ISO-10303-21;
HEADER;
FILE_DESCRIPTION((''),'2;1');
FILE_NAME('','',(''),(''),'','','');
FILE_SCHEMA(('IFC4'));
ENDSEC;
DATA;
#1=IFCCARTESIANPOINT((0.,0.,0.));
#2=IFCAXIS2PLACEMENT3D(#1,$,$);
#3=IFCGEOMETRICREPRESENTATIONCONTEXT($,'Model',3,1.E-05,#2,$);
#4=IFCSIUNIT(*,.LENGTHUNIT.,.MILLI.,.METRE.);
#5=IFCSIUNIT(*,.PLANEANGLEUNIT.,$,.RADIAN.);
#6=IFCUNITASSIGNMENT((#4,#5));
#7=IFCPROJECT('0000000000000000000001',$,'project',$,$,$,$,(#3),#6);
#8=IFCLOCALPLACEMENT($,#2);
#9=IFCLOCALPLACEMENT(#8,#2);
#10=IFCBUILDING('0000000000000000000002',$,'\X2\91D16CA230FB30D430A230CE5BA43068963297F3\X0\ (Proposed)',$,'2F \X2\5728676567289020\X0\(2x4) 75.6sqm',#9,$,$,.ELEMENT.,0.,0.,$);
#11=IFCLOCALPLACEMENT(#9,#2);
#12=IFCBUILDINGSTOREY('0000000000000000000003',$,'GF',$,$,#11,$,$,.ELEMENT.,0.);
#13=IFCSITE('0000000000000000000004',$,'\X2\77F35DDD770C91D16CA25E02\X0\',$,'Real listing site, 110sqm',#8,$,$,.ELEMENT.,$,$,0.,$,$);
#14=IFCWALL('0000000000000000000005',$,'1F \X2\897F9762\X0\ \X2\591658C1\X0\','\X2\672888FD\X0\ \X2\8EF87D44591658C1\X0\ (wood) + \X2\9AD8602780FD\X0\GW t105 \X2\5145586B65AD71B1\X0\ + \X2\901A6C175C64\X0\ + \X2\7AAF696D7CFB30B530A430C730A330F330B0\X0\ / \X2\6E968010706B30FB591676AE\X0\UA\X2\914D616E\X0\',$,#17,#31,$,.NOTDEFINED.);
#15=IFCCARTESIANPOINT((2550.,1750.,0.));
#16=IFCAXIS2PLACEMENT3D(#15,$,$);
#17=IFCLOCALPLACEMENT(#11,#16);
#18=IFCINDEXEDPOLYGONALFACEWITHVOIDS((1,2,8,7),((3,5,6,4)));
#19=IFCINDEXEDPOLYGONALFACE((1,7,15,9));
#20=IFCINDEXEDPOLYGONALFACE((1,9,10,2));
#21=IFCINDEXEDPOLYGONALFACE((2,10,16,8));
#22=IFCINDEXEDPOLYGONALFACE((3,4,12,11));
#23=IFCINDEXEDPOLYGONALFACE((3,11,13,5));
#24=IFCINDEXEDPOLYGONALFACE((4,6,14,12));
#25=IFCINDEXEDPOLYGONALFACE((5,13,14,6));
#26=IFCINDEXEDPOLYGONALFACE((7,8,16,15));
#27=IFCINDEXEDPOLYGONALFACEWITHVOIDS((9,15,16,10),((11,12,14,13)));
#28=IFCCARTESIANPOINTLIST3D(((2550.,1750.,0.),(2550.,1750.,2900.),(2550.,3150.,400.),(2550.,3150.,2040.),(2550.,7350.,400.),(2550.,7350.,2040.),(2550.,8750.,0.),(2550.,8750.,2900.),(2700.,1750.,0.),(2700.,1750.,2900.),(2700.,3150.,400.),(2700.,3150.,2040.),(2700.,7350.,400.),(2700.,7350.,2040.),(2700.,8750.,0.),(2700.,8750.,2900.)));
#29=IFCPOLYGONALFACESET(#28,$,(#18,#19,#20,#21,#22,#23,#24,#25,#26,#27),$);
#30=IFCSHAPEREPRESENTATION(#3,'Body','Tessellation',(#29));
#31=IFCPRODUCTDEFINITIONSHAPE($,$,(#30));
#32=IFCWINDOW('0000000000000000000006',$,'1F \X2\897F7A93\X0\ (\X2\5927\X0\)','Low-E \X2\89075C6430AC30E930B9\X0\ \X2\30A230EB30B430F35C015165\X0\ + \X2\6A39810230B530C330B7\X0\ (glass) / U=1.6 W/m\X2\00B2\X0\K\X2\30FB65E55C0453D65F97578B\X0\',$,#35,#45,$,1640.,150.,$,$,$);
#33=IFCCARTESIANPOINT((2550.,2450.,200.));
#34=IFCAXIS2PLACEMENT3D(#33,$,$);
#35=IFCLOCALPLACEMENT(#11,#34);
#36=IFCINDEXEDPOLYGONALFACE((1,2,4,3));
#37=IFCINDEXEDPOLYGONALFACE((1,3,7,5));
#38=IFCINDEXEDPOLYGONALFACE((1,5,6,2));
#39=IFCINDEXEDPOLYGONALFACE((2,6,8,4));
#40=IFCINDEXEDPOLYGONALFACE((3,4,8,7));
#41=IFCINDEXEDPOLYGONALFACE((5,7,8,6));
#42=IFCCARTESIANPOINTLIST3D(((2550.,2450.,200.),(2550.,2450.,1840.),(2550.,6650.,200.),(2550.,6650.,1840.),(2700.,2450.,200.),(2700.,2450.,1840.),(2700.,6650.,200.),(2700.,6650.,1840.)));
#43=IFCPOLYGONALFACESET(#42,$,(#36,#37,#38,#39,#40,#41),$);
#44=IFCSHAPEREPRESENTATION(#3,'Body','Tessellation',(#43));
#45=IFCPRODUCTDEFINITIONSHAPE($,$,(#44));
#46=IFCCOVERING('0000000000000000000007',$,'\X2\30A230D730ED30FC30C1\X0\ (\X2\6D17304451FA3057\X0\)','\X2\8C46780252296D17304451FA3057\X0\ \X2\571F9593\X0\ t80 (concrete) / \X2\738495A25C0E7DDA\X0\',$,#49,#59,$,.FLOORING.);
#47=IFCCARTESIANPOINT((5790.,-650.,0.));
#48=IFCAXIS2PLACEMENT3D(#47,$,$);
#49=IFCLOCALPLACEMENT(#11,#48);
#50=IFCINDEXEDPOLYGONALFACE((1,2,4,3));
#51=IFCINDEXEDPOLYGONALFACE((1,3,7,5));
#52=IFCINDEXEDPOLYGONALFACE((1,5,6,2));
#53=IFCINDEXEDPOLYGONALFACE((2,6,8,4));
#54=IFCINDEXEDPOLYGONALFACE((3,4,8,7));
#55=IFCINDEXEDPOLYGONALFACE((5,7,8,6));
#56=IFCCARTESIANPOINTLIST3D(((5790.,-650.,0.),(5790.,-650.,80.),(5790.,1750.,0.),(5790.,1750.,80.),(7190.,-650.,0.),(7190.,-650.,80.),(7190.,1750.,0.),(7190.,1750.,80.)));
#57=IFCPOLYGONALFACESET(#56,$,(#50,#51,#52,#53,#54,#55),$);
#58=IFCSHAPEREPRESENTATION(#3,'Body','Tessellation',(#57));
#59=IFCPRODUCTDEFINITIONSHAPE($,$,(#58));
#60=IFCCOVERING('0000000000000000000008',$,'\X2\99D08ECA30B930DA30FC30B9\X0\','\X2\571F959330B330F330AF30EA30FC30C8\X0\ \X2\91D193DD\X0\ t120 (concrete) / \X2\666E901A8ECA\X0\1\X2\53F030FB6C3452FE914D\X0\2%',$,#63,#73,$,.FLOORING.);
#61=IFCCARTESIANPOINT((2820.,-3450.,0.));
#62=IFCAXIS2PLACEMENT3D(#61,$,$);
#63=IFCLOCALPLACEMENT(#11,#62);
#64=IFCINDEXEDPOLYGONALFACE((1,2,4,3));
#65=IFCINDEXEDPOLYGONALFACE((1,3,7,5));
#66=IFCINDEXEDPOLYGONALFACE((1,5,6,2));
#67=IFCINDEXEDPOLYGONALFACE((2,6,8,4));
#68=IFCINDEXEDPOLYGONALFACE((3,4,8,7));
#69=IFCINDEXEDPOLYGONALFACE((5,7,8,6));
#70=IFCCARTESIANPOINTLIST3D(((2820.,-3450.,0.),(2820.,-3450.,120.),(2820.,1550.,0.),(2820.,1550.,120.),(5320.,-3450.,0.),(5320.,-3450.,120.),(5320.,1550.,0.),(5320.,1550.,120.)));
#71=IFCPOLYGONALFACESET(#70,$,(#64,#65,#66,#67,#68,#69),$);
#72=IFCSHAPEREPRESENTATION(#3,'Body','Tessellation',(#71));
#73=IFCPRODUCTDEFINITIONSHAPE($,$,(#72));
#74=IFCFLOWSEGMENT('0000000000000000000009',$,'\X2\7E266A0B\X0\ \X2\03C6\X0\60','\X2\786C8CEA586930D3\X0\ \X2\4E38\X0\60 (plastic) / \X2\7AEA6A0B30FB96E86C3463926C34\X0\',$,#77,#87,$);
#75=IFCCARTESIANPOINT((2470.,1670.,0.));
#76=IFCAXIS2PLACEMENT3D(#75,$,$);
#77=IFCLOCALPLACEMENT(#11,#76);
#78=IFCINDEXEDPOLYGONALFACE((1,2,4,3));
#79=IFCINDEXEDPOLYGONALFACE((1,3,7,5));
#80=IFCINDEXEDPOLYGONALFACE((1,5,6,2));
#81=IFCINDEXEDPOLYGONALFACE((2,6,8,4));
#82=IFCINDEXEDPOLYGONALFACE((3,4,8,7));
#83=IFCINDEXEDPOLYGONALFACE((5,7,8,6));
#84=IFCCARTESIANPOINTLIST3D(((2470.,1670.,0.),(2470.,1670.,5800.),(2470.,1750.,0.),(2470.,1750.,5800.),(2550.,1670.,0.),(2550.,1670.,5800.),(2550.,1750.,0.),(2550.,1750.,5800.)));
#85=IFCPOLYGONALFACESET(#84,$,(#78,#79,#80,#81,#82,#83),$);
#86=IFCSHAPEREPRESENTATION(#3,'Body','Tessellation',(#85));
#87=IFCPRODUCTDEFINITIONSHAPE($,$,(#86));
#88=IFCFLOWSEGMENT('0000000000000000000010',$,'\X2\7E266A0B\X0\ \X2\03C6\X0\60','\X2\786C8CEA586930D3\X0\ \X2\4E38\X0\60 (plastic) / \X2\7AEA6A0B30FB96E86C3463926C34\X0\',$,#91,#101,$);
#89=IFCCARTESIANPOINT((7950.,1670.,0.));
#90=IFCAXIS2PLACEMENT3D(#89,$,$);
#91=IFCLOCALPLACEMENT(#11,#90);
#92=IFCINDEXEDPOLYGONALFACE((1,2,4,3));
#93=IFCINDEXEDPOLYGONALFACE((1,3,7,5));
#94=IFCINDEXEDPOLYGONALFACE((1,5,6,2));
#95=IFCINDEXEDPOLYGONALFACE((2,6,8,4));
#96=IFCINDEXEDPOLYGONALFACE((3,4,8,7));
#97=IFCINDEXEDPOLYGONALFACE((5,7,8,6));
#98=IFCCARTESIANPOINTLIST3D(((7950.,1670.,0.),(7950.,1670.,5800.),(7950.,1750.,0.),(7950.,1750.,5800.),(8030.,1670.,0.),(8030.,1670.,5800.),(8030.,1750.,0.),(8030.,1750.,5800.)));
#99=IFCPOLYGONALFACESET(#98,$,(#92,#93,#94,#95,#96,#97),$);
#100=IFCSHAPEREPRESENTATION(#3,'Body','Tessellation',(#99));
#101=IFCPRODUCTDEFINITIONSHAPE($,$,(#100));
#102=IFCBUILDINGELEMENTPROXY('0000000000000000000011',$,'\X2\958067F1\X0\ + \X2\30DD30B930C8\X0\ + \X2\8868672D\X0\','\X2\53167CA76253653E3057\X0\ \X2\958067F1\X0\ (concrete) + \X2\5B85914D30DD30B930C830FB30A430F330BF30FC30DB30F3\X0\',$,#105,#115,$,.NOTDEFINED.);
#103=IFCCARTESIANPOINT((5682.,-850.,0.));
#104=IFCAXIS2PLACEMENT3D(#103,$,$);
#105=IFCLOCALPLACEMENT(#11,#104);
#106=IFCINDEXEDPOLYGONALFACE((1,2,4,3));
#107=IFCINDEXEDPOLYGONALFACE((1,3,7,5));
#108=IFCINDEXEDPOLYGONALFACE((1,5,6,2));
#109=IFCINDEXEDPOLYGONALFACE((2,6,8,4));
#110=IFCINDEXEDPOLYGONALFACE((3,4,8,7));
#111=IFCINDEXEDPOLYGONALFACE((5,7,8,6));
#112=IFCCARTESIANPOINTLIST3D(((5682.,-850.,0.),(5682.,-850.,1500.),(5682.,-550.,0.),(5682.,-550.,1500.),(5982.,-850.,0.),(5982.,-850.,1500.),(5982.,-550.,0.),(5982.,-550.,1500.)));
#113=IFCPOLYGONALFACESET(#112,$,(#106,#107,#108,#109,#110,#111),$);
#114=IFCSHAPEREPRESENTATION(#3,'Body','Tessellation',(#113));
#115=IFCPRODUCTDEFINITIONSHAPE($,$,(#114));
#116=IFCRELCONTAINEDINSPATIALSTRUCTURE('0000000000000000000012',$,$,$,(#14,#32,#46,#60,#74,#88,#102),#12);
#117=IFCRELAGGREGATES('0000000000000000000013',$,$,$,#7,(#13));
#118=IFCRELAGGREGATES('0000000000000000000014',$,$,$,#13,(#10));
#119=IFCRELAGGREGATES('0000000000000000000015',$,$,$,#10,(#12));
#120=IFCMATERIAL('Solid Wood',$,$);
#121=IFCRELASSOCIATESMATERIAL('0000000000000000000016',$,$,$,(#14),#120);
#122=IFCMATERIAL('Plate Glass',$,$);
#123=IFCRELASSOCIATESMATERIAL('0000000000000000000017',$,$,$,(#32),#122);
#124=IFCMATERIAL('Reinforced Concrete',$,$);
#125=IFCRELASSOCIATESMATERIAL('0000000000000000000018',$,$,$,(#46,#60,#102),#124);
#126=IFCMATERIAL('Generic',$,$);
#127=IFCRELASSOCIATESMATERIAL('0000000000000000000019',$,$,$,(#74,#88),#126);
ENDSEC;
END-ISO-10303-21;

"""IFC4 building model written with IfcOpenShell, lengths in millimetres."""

from ifc_helpers import new_model, si_unit, frame, frame_2d, origin, place, context, project, spatial, rectangle, extrude, material, element, fill, save


model = new_model("IFC4")

# Units and contexts
model_context = context("Model", 3, precision=1e-05, world=origin())
ifc_project = project(units=[si_unit("LENGTHUNIT", "METRE", prefix="MILLI"), si_unit("PLANEANGLEUNIT", "RADIAN")], contexts=[model_context])

# Site, building, storey
site_placement = place(None, origin())
site = spatial("IfcSite", under=ifc_project, at=site_placement, Name="石川県金沢市", ObjectType="Real listing site, 110sqm", CompositionType="ELEMENT", RefElevation=0.0)
building_placement = place(site_placement, origin())
building = spatial("IfcBuilding", under=site, at=building_placement, Name="金沢・ピアノ室と防音 (Proposed)", ObjectType="2F 在来木造(2x4) 75.6sqm", CompositionType="ELEMENT", ElevationOfRefHeight=0.0, ElevationOfTerrain=0.0)
storey_placement = place(building_placement, origin())
storey = spatial("IfcBuildingStorey", under=building, at=storey_placement, Name="GF", CompositionType="ELEMENT", Elevation=0.0)

# Shared definitions
ifc_material_1 = material(Name="Solid Wood")

# Shared definitions
ifc_material_2 = material(Name="Reinforced Concrete")

# Shared definitions
ifc_material_3 = material(Name="Plate Glass")

# Wall, opening, window
wall_1_placement = place(storey_placement, frame((2550.0, 1750.0, 0.0)))
wall_1 = element("IfcWall", 1, at=wall_1_placement, inside=storey, material=ifc_material_1, Name="1F 西面 外壁", Description="木製 軸組外壁 (wood) + 高性能GW t105 充填断熱 + 通気層 + 窯業系サイディング / 準耐火・外皮UA配慮", PredefinedType="NOTDEFINED", context=model_context, shape_type="SweptSolid", body=[
    extrude(rectangle(XDim=150.0, YDim=7000.0, at=frame_2d((75.0, 3500.0))), frame((2550.0, 1750.0, 0.0)), (0.0, 0.0, 1.0), 2900.0),
])
opening_1_placement = place(storey_placement, frame((2550.0, 2450.0, 200.0)))
opening_1 = element("IfcOpeningElement", 2, at=opening_1_placement, cuts=wall_1, PredefinedType="NOTDEFINED", context=model_context, shape_type="SweptSolid", body=[
    extrude(rectangle(XDim=150.0, YDim=4200.0, at=frame_2d((75.0, 2100.0))), frame((2550.0, 2450.0, 200.0)), (0.0, 0.0, 1.0), 1640.0),
])
window_1_placement = place(storey_placement, frame((2550.0, 2450.0, 200.0)))
window_1 = element("IfcWindow", 3, at=window_1_placement, inside=storey, material=ifc_material_3, Name="1F 西窓 (大)", Description="Low-E 複層ガラス アルゴン封入 + 樹脂サッシ (glass) / U=1.6 W/m²K・日射取得型", OverallHeight=1640.0, OverallWidth=150.0, context=model_context, shape_type="SweptSolid", body=[
    extrude(rectangle(XDim=150.0, YDim=4200.0, at=frame_2d((75.0, 2100.0))), frame((2550.0, 2450.0, 200.0)), (0.0, 0.0, 1.0), 1640.0),
])
fill(opening_1, window_1)

# Coverings
covering_1_placement = place(storey_placement, frame((5790.0, -650.0, 0.0)))
element("IfcCovering", 4, at=covering_1_placement, inside=storey, material=ifc_material_2, Name="アプローチ (洗い出し)", Description="豆砂利洗い出し 土間 t80 (concrete) / 玄関導線", PredefinedType="FLOORING", context=model_context, shape_type="SweptSolid", body=[
    extrude(rectangle(XDim=1400.0, YDim=2400.0, at=frame_2d((700.0, 1200.0))), frame((5790.0, -650.0, 0.0)), (0.0, 0.0, 1.0), 80.0),
])
covering_2_placement = place(storey_placement, frame((2820.0, -3450.0, 0.0)))
element("IfcCovering", 5, at=covering_2_placement, inside=storey, material=ifc_material_2, Name="駐車スペース", Description="土間コンクリート 金鏝 t120 (concrete) / 普通車1台・水勾配2%", PredefinedType="FLOORING", context=model_context, shape_type="SweptSolid", body=[
    extrude(rectangle(XDim=2500.0, YDim=5000.0, at=frame_2d((1250.0, 2500.0))), frame((2820.0, -3450.0, 0.0)), (0.0, 0.0, 1.0), 120.0),
])

# Flow segments
ifc_material_4 = material(Name="Generic")
flow_segment_1_placement = place(storey_placement, frame((2470.0, 1670.0, 0.0)))
element("IfcFlowSegment", 6, at=flow_segment_1_placement, inside=storey, material=ifc_material_4, Name="縦樋 φ60", Description="硬質塩ビ 丸60 (plastic) / 竪樋・雨水排水", context=model_context, shape_type="SweptSolid", body=[
    extrude(rectangle(XDim=80.0, YDim=80.0, at=frame_2d((40.0, 40.0))), frame((2470.0, 1670.0, 0.0)), (0.0, 0.0, 1.0), 5800.0),
])
flow_segment_2_placement = place(storey_placement, frame((7950.0, 1670.0, 0.0)))
element("IfcFlowSegment", 7, at=flow_segment_2_placement, inside=storey, material=ifc_material_4, Name="縦樋 φ60", Description="硬質塩ビ 丸60 (plastic) / 竪樋・雨水排水", context=model_context, shape_type="SweptSolid", body=[
    extrude(rectangle(XDim=80.0, YDim=80.0, at=frame_2d((40.0, 40.0))), frame((7950.0, 1670.0, 0.0)), (0.0, 0.0, 1.0), 5800.0),
])

# Building element proxy
proxy_placement = place(storey_placement, frame((5682.0, -850.0, 0.0)))
element("IfcBuildingElementProxy", 8, at=proxy_placement, inside=storey, material=ifc_material_2, Name="門柱 + ポスト + 表札", Description="化粧打放し 門柱 (concrete) + 宅配ポスト・インターホン", PredefinedType="NOTDEFINED", context=model_context, shape_type="SweptSolid", body=[
    extrude(rectangle(XDim=300.0, YDim=300.0, at=frame_2d((150.0, 150.0))), frame((5682.0, -850.0, 0.0)), (0.0, 0.0, 1.0), 1500.0),
])

save(model, "model.ifc")
